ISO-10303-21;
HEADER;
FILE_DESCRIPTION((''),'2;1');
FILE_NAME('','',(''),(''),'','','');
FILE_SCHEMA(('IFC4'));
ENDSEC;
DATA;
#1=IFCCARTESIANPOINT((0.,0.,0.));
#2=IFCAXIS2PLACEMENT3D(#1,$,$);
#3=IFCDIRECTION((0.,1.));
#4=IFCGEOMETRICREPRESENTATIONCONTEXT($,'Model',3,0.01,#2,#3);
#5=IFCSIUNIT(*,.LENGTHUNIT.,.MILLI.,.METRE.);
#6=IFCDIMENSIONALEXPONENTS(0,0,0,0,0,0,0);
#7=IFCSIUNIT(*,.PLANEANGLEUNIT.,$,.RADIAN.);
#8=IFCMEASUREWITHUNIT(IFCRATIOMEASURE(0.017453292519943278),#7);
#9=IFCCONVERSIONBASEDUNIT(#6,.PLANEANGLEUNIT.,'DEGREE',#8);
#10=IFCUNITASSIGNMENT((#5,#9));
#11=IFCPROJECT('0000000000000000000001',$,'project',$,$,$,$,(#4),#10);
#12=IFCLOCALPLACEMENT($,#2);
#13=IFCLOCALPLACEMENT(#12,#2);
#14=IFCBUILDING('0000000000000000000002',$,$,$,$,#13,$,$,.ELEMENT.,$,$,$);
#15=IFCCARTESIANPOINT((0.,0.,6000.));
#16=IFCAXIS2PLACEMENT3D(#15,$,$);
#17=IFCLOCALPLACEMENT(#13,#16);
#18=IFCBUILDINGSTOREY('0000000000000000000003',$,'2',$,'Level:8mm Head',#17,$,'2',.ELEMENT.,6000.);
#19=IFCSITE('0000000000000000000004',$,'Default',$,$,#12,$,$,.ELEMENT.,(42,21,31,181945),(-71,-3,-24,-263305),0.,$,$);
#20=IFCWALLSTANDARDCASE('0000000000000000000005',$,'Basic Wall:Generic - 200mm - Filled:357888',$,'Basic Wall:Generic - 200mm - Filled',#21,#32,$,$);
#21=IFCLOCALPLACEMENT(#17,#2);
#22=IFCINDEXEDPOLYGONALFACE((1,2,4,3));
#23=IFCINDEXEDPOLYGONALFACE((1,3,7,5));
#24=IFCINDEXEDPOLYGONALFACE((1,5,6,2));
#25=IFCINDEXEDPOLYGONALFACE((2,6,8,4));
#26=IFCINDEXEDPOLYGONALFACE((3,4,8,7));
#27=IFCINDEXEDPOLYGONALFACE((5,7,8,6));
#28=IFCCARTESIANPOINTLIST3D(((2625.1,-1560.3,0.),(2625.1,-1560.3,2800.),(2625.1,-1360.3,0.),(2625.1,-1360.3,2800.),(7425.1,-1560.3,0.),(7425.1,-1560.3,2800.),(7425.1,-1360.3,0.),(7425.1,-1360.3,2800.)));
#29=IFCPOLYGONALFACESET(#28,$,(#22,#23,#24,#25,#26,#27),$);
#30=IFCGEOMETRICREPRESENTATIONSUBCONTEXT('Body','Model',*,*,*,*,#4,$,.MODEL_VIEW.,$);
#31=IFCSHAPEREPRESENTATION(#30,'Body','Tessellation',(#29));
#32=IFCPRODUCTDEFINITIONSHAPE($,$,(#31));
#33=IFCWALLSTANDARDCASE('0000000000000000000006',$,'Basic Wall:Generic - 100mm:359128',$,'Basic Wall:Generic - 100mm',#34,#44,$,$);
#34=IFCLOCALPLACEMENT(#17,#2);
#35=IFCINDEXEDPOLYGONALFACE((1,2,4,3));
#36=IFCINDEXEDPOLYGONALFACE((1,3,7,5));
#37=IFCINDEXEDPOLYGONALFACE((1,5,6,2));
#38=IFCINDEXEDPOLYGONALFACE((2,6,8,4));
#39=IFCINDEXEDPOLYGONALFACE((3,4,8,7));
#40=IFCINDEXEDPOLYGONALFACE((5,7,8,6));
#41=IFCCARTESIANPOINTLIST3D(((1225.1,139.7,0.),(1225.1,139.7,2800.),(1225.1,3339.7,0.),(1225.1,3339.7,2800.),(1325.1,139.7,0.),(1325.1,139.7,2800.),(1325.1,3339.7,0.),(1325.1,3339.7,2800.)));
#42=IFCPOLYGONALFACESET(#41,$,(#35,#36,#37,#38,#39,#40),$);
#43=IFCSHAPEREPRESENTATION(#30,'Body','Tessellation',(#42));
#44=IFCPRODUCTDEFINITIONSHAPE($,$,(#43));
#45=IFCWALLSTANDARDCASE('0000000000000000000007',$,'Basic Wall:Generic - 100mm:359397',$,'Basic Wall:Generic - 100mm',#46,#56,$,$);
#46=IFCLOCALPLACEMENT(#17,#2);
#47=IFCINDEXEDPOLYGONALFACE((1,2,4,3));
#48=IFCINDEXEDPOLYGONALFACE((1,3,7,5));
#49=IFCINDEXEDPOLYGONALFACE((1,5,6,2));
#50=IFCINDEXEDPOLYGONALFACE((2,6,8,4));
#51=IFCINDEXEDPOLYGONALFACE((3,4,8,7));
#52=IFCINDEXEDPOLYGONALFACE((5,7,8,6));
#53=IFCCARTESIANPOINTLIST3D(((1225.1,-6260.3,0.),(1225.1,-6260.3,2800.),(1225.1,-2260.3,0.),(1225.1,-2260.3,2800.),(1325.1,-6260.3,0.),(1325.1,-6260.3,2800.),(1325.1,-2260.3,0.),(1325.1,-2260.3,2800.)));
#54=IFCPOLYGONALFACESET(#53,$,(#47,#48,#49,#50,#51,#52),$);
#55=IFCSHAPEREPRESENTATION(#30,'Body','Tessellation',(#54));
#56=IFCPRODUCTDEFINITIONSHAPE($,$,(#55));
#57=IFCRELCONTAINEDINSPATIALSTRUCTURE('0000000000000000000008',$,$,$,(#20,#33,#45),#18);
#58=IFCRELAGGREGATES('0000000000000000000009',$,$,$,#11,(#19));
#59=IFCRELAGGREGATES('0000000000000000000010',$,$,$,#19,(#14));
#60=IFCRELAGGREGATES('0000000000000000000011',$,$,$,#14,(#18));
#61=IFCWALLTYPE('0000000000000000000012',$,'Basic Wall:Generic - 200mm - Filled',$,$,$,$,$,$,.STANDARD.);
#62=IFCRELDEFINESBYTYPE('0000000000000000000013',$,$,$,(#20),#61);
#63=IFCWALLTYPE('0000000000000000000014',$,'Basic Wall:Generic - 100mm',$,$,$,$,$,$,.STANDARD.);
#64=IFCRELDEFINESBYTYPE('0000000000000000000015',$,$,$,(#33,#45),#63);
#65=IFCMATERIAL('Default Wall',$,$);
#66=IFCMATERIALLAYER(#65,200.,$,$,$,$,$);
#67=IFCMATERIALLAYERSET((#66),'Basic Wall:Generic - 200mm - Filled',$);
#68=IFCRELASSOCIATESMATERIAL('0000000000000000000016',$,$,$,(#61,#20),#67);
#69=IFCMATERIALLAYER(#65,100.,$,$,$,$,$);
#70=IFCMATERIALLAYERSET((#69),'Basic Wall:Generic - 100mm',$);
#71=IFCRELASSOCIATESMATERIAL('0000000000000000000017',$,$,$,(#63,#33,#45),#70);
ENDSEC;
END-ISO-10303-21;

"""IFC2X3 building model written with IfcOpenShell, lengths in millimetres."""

from ifc_helpers import new_model, entity, si_unit, converted_unit, direction, frame, frame_2d, origin, place, context, subcontext, project, spatial, rectangle, extrude, material, layer, layer_set, layer_usage, type_object, element, save


model = new_model("IFC2X3")

# Units and contexts
model_context = context("Model", 3, precision=0.01, world=origin(), true_north=direction((0.0, 1.0)))
body_context = subcontext(model_context, "Body", "Model", "MODEL_VIEW")
ifc_project = project(units=[si_unit("LENGTHUNIT", "METRE", prefix="MILLI"), converted_unit("PLANEANGLEUNIT", "DEGREE", entity("IfcRatioMeasure", 0.017453292519943278), si_unit("PLANEANGLEUNIT", "RADIAN"), dimensions=[0, 0, 0, 0, 0, 0, 0])], contexts=[model_context])

# Site, building, storey
site_placement = place(None, origin())
site = spatial("IfcSite", under=ifc_project, at=site_placement, Name="Default", CompositionType="ELEMENT", RefLatitude=(42, 21, 31, 181945), RefLongitude=(-71, -3, -24, -263305), RefElevation=0.0)
building_placement = place(site_placement, origin())
building = spatial("IfcBuilding", under=site, at=building_placement, CompositionType="ELEMENT")
storey_placement = place(building_placement, frame((0.0, 0.0, 6000.0)))
storey = spatial("IfcBuildingStorey", under=building, at=storey_placement, Name="2", ObjectType="Level:8mm Head", LongName="2", CompositionType="ELEMENT", Elevation=6000.0)

# Shared definitions
ifc_material_1 = material(Name="Default Wall")
ifc_layer_1 = layer(ifc_material_1, 200.0)
ifc_layer_set_1 = layer_set([ifc_layer_1], Name="Basic Wall:Generic - 200mm - Filled")
wall_type_1 = type_object("IfcWallType", Name="Basic Wall:Generic - 200mm - Filled", PredefinedType="STANDARD", material=ifc_layer_set_1)

# Walls
ifc_layer_usage_1 = layer_usage(ifc_layer_set_1, "AXIS2", "NEGATIVE", 100.0)
wall_1_placement = place(storey_placement, frame((2625.1, -1460.3, 0.0)))
element("IfcWallStandardCase", 1, at=wall_1_placement, inside=storey, type_object=wall_type_1, material=ifc_layer_usage_1, Name="Basic Wall:Generic - 200mm - Filled:357888", ObjectType="Basic Wall:Generic - 200mm - Filled", context=body_context, shape_type="SweptSolid", body=[
    extrude(rectangle(XDim=4800.0, YDim=200.0, at=frame_2d((2400.0, 0.0), x_axis=(-1.0, 0.0))), origin(), (0.0, 0.0, 1.0), 2800.0),
])
ifc_layer_2 = layer(ifc_material_1, 100.0)
ifc_layer_set_2 = layer_set([ifc_layer_2], Name="Basic Wall:Generic - 100mm")
ifc_layer_usage_2 = layer_usage(ifc_layer_set_2, "AXIS2", "NEGATIVE", 50.0)
wall_type_2 = type_object("IfcWallType", Name="Basic Wall:Generic - 100mm", PredefinedType="STANDARD", material=ifc_layer_set_2)
wall_2_placement = place(storey_placement, frame((1275.1, 139.7, 0.0), z_axis=(0.0, 0.0, 1.0), x_axis=(0.0, 1.0, 0.0)))
element("IfcWallStandardCase", 2, at=wall_2_placement, inside=storey, type_object=wall_type_2, material=ifc_layer_usage_2, Name="Basic Wall:Generic - 100mm:359128", ObjectType="Basic Wall:Generic - 100mm", context=body_context, shape_type="SweptSolid", body=[
    extrude(rectangle(XDim=3200.0, YDim=100.0, at=frame_2d((1600.0, 0.0), x_axis=(-1.0, 0.0))), origin(), (0.0, 0.0, 1.0), 2800.0),
])
ifc_layer_usage_3 = layer_usage(ifc_layer_set_2, "AXIS2", "NEGATIVE", 50.0)
wall_3_placement = place(storey_placement, frame((1275.1, -2260.3, 0.0), z_axis=(0.0, 0.0, 1.0), x_axis=(0.0, -1.0, 0.0)))
element("IfcWallStandardCase", 3, at=wall_3_placement, inside=storey, type_object=wall_type_2, material=ifc_layer_usage_3, Name="Basic Wall:Generic - 100mm:359397", ObjectType="Basic Wall:Generic - 100mm", context=body_context, shape_type="SweptSolid", body=[
    extrude(rectangle(XDim=4000.0, YDim=100.0, at=frame_2d((2000.0, 0.0), x_axis=(-1.0, 0.0))), origin(), (0.0, 0.0, 1.0), 2800.0),
])

save(model, "model.ifc")
